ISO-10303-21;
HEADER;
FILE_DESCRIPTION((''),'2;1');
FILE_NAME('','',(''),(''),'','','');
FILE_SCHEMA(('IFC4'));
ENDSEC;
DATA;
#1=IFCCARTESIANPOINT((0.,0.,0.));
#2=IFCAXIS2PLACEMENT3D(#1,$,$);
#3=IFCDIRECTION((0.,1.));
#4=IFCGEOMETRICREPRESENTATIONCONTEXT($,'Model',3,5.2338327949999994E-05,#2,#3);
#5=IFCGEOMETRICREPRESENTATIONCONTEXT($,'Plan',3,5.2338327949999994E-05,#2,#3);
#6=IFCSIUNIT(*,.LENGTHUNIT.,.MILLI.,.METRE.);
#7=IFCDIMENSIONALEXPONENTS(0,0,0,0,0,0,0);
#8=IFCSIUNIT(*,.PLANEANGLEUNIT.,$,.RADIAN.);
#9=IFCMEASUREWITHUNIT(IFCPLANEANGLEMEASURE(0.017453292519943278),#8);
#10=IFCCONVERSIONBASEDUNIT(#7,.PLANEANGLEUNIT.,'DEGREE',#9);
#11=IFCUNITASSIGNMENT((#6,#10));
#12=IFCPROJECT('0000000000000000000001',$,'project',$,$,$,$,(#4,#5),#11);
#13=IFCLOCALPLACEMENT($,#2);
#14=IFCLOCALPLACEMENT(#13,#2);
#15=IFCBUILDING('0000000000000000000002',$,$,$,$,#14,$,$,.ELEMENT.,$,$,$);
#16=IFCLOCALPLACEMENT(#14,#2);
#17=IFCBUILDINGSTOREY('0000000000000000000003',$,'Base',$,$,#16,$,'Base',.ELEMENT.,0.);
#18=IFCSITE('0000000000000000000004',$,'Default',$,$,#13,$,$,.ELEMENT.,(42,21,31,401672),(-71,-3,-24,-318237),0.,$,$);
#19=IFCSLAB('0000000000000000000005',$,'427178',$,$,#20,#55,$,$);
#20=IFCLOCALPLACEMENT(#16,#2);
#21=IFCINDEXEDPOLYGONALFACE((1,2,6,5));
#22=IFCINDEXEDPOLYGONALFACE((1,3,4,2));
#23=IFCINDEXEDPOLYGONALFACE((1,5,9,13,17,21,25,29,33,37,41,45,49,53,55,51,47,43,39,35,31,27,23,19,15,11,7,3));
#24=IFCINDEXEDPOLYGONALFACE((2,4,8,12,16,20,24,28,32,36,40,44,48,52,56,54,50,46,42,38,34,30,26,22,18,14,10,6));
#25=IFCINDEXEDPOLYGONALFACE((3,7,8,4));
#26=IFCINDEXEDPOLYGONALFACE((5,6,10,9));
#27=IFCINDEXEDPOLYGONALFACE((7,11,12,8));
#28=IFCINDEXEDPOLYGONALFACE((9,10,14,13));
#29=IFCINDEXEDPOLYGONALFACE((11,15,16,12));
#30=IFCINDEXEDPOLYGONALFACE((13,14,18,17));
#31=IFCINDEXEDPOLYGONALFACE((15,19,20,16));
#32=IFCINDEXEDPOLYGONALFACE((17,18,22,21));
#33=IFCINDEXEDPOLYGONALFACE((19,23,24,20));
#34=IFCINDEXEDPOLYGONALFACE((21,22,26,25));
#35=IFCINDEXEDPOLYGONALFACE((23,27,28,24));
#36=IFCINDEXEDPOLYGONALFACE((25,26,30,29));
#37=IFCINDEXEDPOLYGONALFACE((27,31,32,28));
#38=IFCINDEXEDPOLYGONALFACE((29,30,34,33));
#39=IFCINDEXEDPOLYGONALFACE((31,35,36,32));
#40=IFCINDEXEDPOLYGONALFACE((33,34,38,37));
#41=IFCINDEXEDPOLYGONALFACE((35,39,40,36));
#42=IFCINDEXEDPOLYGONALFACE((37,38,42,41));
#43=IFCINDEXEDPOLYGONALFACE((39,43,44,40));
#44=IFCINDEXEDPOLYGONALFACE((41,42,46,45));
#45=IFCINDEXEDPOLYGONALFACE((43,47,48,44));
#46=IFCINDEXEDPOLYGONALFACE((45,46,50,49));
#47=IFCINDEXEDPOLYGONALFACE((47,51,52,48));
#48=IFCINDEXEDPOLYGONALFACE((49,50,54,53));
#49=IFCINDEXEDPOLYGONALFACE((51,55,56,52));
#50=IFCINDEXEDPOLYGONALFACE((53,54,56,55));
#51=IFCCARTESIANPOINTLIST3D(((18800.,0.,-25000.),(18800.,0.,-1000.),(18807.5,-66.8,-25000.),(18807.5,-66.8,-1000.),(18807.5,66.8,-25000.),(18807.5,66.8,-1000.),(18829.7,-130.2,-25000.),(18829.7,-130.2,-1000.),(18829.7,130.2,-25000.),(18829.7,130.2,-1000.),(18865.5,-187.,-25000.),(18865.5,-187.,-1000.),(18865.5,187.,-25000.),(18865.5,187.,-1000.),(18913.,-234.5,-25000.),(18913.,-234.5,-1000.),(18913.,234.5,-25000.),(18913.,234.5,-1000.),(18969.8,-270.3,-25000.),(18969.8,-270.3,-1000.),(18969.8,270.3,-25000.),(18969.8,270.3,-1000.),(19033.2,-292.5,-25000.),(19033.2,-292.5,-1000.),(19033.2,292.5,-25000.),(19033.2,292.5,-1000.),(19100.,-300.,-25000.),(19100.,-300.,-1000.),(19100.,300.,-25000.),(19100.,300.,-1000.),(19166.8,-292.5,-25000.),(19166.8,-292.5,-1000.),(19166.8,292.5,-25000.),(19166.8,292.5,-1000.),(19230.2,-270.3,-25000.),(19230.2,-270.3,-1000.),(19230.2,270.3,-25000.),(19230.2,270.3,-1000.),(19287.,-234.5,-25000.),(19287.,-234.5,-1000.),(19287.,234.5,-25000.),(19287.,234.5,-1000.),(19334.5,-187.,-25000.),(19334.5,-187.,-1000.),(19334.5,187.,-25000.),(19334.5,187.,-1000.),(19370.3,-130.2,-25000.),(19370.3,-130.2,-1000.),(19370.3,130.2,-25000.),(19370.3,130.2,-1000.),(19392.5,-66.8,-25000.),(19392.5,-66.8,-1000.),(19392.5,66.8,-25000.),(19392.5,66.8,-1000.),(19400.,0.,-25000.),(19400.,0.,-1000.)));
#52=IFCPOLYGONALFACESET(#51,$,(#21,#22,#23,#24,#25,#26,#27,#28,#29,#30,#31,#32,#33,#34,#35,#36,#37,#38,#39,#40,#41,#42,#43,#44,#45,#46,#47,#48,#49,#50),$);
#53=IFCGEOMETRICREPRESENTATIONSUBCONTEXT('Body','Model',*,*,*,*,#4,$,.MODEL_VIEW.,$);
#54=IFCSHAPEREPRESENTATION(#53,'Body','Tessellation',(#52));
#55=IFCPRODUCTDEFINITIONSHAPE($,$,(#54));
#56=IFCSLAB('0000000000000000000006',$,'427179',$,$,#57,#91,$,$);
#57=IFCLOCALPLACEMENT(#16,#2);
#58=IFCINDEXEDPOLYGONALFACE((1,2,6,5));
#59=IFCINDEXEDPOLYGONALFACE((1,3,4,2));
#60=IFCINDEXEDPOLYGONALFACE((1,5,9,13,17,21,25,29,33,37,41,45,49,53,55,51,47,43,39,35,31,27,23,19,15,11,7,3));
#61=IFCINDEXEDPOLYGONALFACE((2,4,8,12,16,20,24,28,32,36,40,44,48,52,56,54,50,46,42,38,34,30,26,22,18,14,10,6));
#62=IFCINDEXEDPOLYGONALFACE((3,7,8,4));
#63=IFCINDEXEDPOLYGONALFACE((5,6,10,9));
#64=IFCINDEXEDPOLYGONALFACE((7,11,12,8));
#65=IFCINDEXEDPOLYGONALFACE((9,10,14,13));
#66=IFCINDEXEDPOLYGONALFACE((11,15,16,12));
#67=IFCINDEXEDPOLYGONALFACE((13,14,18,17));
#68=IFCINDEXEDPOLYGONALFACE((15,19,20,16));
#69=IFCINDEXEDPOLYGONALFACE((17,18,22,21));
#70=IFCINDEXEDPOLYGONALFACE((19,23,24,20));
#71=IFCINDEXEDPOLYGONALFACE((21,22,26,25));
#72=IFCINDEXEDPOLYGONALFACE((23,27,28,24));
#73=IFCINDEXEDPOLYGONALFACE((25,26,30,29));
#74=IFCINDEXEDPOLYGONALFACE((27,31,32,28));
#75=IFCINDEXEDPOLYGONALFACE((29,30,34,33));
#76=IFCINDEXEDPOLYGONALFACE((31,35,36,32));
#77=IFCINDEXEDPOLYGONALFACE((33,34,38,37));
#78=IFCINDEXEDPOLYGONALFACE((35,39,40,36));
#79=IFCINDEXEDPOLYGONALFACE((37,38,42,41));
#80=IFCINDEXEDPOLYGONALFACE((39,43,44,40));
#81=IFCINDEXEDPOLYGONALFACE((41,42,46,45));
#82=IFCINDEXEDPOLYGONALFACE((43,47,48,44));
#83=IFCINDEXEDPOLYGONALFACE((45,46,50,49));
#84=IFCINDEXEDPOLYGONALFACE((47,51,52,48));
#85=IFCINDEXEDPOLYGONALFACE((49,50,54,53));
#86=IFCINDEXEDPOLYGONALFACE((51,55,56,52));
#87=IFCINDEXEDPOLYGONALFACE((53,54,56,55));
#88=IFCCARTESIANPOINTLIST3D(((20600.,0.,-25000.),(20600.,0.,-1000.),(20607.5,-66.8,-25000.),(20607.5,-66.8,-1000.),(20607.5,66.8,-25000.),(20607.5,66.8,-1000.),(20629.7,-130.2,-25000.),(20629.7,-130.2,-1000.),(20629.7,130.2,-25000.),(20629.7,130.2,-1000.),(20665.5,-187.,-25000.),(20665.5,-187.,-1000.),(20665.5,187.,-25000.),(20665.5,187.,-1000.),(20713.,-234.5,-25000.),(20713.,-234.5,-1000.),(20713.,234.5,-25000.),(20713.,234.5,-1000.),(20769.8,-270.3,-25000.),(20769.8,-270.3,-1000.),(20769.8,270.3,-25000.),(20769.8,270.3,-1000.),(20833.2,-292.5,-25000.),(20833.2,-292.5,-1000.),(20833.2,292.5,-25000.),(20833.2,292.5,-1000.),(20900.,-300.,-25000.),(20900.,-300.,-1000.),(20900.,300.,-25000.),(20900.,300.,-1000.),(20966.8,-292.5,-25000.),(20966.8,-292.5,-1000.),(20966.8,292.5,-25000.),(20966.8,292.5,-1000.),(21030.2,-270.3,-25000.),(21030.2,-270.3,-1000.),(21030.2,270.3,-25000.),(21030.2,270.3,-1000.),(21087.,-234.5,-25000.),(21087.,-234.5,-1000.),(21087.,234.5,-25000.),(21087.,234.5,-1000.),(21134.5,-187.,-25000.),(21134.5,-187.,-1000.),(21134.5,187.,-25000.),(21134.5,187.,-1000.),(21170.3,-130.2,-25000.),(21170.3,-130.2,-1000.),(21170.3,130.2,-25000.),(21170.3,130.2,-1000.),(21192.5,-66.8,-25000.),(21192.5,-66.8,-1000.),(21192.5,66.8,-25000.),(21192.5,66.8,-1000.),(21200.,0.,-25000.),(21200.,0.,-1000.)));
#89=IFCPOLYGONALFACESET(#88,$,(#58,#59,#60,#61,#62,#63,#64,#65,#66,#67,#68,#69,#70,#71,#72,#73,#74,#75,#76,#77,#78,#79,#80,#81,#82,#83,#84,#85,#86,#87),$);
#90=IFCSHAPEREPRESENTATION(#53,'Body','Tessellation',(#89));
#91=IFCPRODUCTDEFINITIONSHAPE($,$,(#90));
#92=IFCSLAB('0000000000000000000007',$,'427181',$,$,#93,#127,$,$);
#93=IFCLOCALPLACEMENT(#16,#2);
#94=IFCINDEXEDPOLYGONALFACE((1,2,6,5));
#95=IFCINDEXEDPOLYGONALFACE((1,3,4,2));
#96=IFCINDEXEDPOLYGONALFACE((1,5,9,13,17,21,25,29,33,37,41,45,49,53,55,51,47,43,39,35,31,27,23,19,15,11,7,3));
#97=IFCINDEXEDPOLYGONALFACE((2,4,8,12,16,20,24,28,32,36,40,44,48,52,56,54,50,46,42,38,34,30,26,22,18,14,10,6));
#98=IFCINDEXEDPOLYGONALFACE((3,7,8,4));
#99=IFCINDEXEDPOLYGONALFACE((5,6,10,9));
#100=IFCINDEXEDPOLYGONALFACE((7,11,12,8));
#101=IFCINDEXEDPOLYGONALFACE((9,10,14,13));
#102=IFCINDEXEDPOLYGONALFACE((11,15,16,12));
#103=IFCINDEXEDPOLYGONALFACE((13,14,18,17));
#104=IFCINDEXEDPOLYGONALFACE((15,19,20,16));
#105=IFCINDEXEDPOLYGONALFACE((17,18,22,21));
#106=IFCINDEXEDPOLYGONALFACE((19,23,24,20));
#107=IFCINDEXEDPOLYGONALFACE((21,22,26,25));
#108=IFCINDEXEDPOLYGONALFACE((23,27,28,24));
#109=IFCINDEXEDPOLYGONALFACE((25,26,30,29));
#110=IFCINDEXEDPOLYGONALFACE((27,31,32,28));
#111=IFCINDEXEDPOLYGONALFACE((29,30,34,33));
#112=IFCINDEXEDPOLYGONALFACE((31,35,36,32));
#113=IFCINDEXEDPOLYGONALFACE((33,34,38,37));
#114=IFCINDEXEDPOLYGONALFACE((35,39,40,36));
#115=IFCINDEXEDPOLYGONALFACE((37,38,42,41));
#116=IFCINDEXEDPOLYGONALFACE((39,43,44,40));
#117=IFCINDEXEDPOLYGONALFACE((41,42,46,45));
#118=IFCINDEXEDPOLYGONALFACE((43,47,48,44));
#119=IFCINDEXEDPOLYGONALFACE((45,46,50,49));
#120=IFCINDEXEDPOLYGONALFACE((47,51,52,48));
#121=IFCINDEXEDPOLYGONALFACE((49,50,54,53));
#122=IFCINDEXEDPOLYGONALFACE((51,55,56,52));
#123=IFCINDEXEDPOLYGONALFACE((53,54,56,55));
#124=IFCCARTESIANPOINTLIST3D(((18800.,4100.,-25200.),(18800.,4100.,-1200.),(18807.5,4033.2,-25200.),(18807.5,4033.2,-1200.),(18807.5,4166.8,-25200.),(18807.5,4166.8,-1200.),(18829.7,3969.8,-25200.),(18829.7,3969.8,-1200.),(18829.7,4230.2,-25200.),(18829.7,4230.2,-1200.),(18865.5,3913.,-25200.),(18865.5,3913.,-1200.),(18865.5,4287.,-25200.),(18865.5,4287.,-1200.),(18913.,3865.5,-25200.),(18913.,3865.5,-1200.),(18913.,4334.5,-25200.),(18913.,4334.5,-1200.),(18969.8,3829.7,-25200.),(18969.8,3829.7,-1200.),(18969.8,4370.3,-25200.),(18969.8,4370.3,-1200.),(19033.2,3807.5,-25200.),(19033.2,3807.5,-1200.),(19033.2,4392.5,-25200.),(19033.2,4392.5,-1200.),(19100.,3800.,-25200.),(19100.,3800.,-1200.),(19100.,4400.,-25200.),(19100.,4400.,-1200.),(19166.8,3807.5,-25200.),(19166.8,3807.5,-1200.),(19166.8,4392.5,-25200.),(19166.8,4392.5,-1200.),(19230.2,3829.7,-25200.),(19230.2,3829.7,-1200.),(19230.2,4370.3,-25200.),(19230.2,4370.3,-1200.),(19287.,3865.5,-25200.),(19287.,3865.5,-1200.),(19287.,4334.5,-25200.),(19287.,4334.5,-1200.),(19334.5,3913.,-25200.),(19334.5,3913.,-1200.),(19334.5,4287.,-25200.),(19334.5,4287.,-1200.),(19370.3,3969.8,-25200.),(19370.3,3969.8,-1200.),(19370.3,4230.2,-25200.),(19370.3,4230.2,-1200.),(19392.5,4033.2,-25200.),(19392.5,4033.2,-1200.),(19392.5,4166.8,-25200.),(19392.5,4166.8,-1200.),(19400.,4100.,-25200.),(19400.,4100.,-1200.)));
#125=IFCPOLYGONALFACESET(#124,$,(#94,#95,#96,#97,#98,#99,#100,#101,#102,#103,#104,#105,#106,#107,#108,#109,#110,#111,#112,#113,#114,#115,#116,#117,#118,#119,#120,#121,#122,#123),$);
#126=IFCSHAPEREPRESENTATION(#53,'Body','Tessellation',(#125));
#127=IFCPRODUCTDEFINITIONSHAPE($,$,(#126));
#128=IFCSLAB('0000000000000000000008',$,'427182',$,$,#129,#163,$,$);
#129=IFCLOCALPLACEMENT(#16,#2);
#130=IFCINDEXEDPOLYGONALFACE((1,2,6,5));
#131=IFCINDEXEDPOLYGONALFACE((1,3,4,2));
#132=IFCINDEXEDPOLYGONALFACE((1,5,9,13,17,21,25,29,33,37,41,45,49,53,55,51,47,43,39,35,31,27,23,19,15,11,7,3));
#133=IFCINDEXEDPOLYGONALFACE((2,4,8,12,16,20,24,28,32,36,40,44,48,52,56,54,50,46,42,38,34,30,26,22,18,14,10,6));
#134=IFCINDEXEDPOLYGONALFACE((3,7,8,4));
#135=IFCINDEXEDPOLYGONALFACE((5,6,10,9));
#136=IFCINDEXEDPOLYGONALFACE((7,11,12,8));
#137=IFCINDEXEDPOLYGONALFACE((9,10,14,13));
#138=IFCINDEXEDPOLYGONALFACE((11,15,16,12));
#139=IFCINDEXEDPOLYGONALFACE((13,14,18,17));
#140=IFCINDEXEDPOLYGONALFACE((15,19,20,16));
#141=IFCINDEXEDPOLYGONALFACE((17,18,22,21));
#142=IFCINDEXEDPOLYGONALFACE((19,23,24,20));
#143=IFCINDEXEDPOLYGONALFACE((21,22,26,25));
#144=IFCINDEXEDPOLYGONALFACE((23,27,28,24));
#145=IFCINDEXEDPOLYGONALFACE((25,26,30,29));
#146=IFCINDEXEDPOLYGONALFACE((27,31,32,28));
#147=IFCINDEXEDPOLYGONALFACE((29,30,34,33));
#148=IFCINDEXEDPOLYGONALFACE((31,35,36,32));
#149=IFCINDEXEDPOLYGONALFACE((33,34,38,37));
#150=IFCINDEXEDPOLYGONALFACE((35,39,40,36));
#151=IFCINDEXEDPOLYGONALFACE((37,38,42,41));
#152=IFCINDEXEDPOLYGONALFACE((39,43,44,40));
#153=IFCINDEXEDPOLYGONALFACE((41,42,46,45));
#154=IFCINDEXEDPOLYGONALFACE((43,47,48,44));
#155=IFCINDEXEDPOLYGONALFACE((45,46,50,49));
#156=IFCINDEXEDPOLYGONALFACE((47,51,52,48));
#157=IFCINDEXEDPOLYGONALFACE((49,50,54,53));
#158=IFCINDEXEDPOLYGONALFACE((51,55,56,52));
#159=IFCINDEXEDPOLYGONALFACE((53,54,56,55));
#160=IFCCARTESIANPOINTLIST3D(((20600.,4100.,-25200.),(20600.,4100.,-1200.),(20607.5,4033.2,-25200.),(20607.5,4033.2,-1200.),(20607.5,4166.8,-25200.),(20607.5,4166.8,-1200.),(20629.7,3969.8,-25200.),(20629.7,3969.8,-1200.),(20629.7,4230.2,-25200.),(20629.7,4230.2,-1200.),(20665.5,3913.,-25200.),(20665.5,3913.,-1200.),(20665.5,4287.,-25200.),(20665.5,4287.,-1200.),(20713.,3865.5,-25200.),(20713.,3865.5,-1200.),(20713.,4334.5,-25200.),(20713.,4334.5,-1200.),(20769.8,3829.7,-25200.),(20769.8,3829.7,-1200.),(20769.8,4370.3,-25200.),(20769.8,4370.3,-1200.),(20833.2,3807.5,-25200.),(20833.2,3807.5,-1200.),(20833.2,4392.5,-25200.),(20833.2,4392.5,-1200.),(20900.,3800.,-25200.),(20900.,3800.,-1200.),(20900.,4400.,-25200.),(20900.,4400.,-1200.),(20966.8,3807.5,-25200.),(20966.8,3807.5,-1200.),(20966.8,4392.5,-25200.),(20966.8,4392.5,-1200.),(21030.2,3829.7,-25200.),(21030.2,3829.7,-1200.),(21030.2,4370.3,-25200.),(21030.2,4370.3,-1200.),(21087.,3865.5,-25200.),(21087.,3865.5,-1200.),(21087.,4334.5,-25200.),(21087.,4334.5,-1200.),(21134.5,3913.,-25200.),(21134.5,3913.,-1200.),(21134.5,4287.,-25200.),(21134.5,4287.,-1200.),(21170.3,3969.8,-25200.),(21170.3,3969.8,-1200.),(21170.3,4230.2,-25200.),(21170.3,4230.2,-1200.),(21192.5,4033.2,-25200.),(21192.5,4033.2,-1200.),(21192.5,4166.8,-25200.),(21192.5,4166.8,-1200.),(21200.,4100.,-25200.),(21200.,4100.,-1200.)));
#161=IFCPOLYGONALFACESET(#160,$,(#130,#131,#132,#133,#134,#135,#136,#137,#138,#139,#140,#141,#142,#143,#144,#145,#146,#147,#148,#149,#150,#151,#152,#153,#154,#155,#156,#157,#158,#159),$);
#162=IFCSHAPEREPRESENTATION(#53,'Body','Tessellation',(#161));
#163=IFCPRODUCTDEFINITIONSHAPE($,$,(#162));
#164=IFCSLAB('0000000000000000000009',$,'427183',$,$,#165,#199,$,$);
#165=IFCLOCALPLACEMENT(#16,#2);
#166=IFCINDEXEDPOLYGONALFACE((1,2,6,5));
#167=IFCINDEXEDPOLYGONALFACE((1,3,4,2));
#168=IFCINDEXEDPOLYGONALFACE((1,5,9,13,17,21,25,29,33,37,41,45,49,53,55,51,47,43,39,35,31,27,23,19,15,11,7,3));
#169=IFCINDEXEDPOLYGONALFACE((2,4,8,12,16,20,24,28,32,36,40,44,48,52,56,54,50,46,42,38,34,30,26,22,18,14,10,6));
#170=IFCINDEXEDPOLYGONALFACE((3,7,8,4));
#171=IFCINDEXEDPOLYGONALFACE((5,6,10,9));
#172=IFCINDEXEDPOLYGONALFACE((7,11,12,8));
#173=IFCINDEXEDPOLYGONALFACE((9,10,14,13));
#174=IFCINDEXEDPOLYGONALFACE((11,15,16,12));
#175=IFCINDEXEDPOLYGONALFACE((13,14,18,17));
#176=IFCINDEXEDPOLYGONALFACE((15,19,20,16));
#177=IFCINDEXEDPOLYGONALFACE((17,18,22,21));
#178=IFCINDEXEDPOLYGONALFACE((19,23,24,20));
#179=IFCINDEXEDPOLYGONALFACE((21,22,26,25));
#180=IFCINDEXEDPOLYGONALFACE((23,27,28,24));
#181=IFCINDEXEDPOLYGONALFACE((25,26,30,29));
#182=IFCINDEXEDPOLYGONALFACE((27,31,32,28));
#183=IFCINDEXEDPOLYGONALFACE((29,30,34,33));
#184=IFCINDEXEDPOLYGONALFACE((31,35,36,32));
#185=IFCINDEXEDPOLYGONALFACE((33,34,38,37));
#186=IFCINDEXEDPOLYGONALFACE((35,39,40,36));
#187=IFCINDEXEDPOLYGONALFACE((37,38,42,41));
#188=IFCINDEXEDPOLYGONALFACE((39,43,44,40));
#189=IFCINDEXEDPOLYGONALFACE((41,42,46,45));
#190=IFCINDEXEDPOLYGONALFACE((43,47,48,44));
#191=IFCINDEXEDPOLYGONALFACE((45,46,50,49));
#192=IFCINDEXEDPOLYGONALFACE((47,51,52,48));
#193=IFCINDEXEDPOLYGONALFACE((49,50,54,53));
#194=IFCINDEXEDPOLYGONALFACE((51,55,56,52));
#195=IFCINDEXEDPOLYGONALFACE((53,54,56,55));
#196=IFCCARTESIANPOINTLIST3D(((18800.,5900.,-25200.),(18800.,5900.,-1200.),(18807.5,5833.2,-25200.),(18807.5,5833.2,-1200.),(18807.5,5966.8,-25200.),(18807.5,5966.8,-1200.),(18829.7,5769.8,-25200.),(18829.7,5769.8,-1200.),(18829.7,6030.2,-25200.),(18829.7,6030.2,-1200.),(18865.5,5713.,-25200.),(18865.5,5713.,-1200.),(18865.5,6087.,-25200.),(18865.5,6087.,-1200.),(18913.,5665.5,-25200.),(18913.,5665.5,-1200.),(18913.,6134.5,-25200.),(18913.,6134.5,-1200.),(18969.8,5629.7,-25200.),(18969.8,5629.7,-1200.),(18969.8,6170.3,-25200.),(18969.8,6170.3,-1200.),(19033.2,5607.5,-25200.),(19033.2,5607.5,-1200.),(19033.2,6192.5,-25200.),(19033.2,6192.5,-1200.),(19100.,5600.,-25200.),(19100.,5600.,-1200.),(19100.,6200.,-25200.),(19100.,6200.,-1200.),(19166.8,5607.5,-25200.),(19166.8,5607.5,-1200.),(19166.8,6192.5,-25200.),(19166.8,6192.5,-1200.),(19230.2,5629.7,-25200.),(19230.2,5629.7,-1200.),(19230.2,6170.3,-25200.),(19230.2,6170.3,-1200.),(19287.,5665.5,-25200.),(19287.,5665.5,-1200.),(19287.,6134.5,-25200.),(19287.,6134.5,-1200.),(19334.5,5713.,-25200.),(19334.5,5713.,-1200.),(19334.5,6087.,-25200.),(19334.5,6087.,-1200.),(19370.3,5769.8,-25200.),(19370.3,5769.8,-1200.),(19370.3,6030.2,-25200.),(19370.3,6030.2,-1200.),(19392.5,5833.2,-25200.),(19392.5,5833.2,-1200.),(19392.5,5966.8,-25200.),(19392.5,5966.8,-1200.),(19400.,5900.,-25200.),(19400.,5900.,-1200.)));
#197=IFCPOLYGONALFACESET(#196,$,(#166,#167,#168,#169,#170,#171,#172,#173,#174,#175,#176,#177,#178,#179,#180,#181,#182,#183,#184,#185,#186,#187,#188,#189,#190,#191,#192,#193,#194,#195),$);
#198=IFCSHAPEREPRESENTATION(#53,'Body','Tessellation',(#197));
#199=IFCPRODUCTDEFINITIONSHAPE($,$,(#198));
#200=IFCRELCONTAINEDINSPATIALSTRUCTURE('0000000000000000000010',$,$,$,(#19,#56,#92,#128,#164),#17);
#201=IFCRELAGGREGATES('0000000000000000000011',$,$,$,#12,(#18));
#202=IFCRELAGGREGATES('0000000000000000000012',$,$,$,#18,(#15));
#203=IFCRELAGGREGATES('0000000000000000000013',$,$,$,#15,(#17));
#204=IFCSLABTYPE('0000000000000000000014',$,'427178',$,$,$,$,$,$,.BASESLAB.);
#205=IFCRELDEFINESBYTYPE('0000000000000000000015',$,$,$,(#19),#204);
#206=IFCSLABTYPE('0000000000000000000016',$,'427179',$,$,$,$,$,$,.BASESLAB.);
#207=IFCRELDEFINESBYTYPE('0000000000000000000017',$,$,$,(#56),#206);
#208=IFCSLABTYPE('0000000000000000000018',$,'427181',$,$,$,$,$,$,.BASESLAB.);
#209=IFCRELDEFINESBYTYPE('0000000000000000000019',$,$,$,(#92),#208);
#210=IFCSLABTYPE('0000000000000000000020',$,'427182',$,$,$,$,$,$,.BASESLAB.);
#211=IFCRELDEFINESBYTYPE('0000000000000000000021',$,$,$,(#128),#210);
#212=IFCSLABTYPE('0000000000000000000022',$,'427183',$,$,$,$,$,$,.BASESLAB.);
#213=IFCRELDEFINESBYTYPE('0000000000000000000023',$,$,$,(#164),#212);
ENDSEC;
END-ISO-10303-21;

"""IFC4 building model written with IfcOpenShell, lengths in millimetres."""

from ifc_helpers import new_model, entity, si_unit, converted_unit, direction, frame, origin, place, context, subcontext, project, spatial, arc, indexed_curve, outline, extrude, type_object, element, save


model = new_model("IFC4")

# Units and contexts
model_context = context("Model", 3, precision=5.2338327949999994e-05, world=origin(), true_north=direction((0.0, 1.0)))
plan_context = context("Plan", 3, precision=5.2338327949999994e-05, world=origin(), true_north=direction((0.0, 1.0)))
body_context = subcontext(model_context, "Body", "Model", "MODEL_VIEW")
ifc_project = project(units=[si_unit("LENGTHUNIT", "METRE", prefix="MILLI"), converted_unit("PLANEANGLEUNIT", "DEGREE", entity("IfcPlaneAngleMeasure", 0.017453292519943278), si_unit("PLANEANGLEUNIT", "RADIAN"), dimensions=[0, 0, 0, 0, 0, 0, 0])], contexts=[model_context, plan_context])

# Site, building, storey
site_placement = place(None, origin())
site = spatial("IfcSite", under=ifc_project, at=site_placement, Name="Default", CompositionType="ELEMENT", RefLatitude=(42, 21, 31, 401672), RefLongitude=(-71, -3, -24, -318237), RefElevation=0.0)
building_placement = place(site_placement, origin())
building = spatial("IfcBuilding", under=site, at=building_placement, CompositionType="ELEMENT")
storey_placement = place(building_placement, origin())
storey = spatial("IfcBuildingStorey", under=building, at=storey_placement, Name="Base", LongName="Base", CompositionType="ELEMENT", Elevation=0.0)

# Slabs
slab_type_1 = type_object("IfcSlabType", Name="427178", PredefinedType="BASESLAB")
slab_1_placement = place(storey_placement, origin())
element("IfcSlab", 1, at=slab_1_placement, inside=storey, type_object=slab_type_1, Name="427178", context=body_context, shape_type="SweptSolid", body=[
    extrude(outline(indexed_curve([(300.0, 0.0), (0.0, 300.0), (-300.0, 0.0), (0.0, -300.0)], segments=[arc(1, 2, 3), arc(3, 4, 1)], self_intersect=False)), frame((19100.0, 0.0, -25000.0)), (0.0, 0.0, 1.0), 24000.0),
])
slab_type_2 = type_object("IfcSlabType", Name="427179", PredefinedType="BASESLAB")
slab_2_placement = place(storey_placement, origin())
element("IfcSlab", 2, at=slab_2_placement, inside=storey, type_object=slab_type_2, Name="427179", context=body_context, shape_type="SweptSolid", body=[
    extrude(outline(indexed_curve([(300.0, 0.0), (0.0, 300.0), (-300.0, 0.0), (0.0, -300.0)], segments=[arc(1, 2, 3), arc(3, 4, 1)], self_intersect=False)), frame((20900.0, 0.0, -25000.0)), (0.0, 0.0, 1.0), 24000.0),
])
slab_type_3 = type_object("IfcSlabType", Name="427181", PredefinedType="BASESLAB")
slab_3_placement = place(storey_placement, origin())
element("IfcSlab", 3, at=slab_3_placement, inside=storey, type_object=slab_type_3, Name="427181", context=body_context, shape_type="SweptSolid", body=[
    extrude(outline(indexed_curve([(300.0, 0.0), (0.0, 300.0), (-300.0, 0.0), (0.0, -300.0)], segments=[arc(1, 2, 3), arc(3, 4, 1)], self_intersect=False)), frame((19100.0, 4100.0, -25200.0)), (0.0, 0.0, 1.0), 24000.0),
])
slab_type_4 = type_object("IfcSlabType", Name="427182", PredefinedType="BASESLAB")
slab_4_placement = place(storey_placement, origin())
element("IfcSlab", 4, at=slab_4_placement, inside=storey, type_object=slab_type_4, Name="427182", context=body_context, shape_type="SweptSolid", body=[
    extrude(outline(indexed_curve([(300.0, 0.0), (0.0, 300.0), (-300.0, 0.0), (0.0, -300.0)], segments=[arc(1, 2, 3), arc(3, 4, 1)], self_intersect=False)), frame((20900.0, 4100.0, -25200.0)), (0.0, 0.0, 1.0), 24000.0),
])
slab_type_5 = type_object("IfcSlabType", Name="427183", PredefinedType="BASESLAB")
slab_5_placement = place(storey_placement, origin())
element("IfcSlab", 5, at=slab_5_placement, inside=storey, type_object=slab_type_5, Name="427183", context=body_context, shape_type="SweptSolid", body=[
    extrude(outline(indexed_curve([(300.0, 0.0), (0.0, 300.0), (-300.0, 0.0), (0.0, -300.0)], segments=[arc(1, 2, 3), arc(3, 4, 1)], self_intersect=False)), frame((19100.0, 5900.0, -25200.0)), (0.0, 0.0, 1.0), 24000.0),
])

save(model, "model.ifc")
